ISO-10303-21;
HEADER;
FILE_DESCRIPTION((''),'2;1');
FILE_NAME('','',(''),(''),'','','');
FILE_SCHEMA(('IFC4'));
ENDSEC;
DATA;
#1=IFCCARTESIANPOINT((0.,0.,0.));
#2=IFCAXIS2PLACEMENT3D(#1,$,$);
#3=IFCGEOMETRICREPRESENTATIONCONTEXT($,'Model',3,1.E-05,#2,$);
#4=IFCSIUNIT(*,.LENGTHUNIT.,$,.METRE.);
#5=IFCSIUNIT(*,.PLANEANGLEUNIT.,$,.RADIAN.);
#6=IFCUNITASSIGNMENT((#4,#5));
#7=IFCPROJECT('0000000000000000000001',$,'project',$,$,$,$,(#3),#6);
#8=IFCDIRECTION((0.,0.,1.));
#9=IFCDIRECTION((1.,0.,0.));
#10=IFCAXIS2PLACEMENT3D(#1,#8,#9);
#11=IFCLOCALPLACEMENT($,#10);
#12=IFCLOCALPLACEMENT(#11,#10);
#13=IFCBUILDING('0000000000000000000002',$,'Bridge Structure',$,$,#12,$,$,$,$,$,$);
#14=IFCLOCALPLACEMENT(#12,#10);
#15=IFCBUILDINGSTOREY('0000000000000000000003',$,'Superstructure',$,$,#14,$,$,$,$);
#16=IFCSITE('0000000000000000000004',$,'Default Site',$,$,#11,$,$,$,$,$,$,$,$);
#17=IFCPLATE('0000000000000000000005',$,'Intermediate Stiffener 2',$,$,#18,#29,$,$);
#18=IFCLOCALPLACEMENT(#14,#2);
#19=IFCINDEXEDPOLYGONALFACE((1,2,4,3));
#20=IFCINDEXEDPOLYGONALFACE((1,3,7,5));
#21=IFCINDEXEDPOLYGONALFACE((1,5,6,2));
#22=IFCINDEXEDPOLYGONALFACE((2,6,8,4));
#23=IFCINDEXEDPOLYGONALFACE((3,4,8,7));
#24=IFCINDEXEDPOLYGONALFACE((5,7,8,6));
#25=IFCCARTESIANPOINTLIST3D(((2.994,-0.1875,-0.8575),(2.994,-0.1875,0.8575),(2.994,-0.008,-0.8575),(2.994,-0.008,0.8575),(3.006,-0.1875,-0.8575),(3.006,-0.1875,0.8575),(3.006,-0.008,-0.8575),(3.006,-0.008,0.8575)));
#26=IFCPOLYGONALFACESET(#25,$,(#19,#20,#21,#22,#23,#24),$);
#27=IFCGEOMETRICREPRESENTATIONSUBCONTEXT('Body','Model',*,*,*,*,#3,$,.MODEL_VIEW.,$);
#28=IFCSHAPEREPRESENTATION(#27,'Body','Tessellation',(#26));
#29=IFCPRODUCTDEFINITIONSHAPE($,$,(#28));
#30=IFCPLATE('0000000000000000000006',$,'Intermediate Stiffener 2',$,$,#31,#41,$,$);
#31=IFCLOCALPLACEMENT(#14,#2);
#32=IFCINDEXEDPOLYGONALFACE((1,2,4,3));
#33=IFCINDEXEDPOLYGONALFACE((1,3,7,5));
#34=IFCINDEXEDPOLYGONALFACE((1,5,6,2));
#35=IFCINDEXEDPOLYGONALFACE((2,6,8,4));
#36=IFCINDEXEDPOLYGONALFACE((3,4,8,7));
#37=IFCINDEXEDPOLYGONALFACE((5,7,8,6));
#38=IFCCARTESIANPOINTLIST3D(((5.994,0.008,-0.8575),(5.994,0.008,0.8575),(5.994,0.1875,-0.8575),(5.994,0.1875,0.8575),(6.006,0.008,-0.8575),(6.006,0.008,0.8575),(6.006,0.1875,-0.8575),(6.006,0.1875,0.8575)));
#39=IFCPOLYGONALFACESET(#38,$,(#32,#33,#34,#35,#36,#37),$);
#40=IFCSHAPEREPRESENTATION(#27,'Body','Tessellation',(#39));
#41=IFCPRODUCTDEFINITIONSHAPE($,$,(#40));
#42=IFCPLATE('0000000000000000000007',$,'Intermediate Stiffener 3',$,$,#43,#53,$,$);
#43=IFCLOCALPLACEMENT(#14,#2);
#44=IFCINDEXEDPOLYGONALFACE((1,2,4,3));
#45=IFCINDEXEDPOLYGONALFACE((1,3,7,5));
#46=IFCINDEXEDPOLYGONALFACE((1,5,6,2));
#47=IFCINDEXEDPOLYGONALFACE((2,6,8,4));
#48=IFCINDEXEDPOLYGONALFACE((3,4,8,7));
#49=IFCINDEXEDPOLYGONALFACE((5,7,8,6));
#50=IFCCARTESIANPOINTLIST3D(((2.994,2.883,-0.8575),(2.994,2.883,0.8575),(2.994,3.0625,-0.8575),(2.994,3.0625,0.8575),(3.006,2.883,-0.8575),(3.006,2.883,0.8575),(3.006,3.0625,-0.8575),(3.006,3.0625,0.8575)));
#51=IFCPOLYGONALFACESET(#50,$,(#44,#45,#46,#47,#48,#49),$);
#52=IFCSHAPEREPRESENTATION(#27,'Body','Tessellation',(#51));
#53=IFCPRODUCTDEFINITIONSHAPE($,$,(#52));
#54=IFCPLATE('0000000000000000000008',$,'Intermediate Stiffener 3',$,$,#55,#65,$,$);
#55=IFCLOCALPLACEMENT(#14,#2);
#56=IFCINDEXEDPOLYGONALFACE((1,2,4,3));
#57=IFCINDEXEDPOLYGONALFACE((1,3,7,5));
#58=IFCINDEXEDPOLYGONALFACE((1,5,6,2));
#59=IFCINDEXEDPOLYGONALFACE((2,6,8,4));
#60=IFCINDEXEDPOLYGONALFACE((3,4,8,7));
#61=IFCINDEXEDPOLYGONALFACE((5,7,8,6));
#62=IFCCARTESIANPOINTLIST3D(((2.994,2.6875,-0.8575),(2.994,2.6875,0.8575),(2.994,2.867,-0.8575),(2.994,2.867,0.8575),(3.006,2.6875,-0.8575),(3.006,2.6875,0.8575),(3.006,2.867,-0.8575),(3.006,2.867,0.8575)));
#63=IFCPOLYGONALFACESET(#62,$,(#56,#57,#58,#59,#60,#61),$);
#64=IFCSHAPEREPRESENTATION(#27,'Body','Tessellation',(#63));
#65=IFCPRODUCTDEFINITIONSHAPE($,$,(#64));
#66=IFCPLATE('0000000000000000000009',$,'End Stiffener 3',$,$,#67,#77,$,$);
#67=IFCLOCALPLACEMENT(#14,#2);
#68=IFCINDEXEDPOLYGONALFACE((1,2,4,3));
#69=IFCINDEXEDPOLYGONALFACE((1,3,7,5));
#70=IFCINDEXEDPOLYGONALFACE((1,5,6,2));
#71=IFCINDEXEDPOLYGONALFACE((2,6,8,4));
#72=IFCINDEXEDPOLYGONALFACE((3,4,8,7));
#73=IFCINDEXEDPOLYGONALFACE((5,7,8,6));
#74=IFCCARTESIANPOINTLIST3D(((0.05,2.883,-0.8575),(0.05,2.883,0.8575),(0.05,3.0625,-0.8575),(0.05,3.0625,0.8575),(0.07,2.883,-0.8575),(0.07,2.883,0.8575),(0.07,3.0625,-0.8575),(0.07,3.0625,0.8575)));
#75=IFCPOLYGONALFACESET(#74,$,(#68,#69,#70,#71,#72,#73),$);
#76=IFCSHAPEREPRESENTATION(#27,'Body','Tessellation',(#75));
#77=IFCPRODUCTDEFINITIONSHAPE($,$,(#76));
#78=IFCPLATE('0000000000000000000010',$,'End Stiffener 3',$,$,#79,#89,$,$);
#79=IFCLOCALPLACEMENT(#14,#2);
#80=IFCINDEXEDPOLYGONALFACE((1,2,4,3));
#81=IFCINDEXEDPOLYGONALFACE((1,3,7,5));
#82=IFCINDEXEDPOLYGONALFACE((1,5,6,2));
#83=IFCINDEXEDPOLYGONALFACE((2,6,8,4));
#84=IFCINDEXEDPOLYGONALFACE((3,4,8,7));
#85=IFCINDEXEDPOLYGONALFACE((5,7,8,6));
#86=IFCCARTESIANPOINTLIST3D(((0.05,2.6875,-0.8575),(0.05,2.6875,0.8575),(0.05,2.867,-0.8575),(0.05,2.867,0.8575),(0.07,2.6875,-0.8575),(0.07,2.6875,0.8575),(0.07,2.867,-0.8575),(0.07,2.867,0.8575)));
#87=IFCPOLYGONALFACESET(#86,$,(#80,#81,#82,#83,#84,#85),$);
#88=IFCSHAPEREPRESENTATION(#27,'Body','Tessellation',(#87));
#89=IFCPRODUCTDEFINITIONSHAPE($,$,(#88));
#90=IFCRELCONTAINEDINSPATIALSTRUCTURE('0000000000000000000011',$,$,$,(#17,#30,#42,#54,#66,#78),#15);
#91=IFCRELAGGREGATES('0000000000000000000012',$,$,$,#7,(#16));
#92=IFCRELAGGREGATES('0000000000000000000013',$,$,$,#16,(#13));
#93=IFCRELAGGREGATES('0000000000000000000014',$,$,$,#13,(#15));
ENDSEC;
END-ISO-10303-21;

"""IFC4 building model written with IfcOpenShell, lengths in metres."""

from ifc_helpers import new_model, si_unit, frame, origin, origin_with_axes, origin_2d_with_axis, place, context, subcontext, project, spatial, rectangle, extrude, element, save


model = new_model("IFC4")

# Units and contexts
model_context = context("Model", 3, precision=1e-05, world=origin())
body_context = subcontext(model_context, "Body", "Model", "MODEL_VIEW")
ifc_project = project(units=[si_unit("LENGTHUNIT", "METRE"), si_unit("PLANEANGLEUNIT", "RADIAN")], contexts=[model_context])

# Site, building, storey
site_placement = place(None, origin_with_axes())
site = spatial("IfcSite", under=ifc_project, at=site_placement, Name="Default Site")
building_placement = place(site_placement, origin_with_axes())
building = spatial("IfcBuilding", under=site, at=building_placement, Name="Bridge Structure")
storey_placement = place(building_placement, origin_with_axes())
storey = spatial("IfcBuildingStorey", under=building, at=storey_placement, Name="Superstructure")

# Plates
for number, where, z_axis, x_axis, name in (
    (1, (3.0, -0.0978, -0.8575), (0.0, 0.0, 1.0), (1.0, 0.0, 0.0), "Intermediate Stiffener 2"),
    (2, (6.0, 0.0978, -0.8575), (0.0, 0.0, 1.0), (1.0, 0.0, 0.0), "Intermediate Stiffener 2"),
    (3, (3.0, 2.9728, -0.8575), (0.0, 0.0, 1.0), (1.0, 0.0, 0.0), "Intermediate Stiffener 3"),
    (4, (3.0, 2.7772, -0.8575), (0.0, 0.0, 1.0), (1.0, 0.0, 0.0), "Intermediate Stiffener 3"),
):
    element("IfcPlate", number, at=place(storey_placement, frame(where, z_axis=z_axis, x_axis=x_axis)), inside=storey, Name=name, context=body_context, shape_type="SweptSolid", body=[
        extrude(rectangle(XDim=0.012, YDim=0.1795, at=origin_2d_with_axis()), origin_with_axes(), (0.0, 0.0, 1.0), 1.715),
    ])
for number, where, z_axis, x_axis, name in (
    (5, (0.06, 2.9728, -0.8575), (0.0, 0.0, 1.0), (1.0, 0.0, 0.0), "End Stiffener 3"),
    (6, (0.06, 2.7772, -0.8575), (0.0, 0.0, 1.0), (1.0, 0.0, 0.0), "End Stiffener 3"),
):
    element("IfcPlate", number, at=place(storey_placement, frame(where, z_axis=z_axis, x_axis=x_axis)), inside=storey, Name=name, context=body_context, shape_type="SweptSolid", body=[
        extrude(rectangle(XDim=0.02, YDim=0.1795, at=origin_2d_with_axis()), origin_with_axes(), (0.0, 0.0, 1.0), 1.715),
    ])

save(model, "model.ifc")
